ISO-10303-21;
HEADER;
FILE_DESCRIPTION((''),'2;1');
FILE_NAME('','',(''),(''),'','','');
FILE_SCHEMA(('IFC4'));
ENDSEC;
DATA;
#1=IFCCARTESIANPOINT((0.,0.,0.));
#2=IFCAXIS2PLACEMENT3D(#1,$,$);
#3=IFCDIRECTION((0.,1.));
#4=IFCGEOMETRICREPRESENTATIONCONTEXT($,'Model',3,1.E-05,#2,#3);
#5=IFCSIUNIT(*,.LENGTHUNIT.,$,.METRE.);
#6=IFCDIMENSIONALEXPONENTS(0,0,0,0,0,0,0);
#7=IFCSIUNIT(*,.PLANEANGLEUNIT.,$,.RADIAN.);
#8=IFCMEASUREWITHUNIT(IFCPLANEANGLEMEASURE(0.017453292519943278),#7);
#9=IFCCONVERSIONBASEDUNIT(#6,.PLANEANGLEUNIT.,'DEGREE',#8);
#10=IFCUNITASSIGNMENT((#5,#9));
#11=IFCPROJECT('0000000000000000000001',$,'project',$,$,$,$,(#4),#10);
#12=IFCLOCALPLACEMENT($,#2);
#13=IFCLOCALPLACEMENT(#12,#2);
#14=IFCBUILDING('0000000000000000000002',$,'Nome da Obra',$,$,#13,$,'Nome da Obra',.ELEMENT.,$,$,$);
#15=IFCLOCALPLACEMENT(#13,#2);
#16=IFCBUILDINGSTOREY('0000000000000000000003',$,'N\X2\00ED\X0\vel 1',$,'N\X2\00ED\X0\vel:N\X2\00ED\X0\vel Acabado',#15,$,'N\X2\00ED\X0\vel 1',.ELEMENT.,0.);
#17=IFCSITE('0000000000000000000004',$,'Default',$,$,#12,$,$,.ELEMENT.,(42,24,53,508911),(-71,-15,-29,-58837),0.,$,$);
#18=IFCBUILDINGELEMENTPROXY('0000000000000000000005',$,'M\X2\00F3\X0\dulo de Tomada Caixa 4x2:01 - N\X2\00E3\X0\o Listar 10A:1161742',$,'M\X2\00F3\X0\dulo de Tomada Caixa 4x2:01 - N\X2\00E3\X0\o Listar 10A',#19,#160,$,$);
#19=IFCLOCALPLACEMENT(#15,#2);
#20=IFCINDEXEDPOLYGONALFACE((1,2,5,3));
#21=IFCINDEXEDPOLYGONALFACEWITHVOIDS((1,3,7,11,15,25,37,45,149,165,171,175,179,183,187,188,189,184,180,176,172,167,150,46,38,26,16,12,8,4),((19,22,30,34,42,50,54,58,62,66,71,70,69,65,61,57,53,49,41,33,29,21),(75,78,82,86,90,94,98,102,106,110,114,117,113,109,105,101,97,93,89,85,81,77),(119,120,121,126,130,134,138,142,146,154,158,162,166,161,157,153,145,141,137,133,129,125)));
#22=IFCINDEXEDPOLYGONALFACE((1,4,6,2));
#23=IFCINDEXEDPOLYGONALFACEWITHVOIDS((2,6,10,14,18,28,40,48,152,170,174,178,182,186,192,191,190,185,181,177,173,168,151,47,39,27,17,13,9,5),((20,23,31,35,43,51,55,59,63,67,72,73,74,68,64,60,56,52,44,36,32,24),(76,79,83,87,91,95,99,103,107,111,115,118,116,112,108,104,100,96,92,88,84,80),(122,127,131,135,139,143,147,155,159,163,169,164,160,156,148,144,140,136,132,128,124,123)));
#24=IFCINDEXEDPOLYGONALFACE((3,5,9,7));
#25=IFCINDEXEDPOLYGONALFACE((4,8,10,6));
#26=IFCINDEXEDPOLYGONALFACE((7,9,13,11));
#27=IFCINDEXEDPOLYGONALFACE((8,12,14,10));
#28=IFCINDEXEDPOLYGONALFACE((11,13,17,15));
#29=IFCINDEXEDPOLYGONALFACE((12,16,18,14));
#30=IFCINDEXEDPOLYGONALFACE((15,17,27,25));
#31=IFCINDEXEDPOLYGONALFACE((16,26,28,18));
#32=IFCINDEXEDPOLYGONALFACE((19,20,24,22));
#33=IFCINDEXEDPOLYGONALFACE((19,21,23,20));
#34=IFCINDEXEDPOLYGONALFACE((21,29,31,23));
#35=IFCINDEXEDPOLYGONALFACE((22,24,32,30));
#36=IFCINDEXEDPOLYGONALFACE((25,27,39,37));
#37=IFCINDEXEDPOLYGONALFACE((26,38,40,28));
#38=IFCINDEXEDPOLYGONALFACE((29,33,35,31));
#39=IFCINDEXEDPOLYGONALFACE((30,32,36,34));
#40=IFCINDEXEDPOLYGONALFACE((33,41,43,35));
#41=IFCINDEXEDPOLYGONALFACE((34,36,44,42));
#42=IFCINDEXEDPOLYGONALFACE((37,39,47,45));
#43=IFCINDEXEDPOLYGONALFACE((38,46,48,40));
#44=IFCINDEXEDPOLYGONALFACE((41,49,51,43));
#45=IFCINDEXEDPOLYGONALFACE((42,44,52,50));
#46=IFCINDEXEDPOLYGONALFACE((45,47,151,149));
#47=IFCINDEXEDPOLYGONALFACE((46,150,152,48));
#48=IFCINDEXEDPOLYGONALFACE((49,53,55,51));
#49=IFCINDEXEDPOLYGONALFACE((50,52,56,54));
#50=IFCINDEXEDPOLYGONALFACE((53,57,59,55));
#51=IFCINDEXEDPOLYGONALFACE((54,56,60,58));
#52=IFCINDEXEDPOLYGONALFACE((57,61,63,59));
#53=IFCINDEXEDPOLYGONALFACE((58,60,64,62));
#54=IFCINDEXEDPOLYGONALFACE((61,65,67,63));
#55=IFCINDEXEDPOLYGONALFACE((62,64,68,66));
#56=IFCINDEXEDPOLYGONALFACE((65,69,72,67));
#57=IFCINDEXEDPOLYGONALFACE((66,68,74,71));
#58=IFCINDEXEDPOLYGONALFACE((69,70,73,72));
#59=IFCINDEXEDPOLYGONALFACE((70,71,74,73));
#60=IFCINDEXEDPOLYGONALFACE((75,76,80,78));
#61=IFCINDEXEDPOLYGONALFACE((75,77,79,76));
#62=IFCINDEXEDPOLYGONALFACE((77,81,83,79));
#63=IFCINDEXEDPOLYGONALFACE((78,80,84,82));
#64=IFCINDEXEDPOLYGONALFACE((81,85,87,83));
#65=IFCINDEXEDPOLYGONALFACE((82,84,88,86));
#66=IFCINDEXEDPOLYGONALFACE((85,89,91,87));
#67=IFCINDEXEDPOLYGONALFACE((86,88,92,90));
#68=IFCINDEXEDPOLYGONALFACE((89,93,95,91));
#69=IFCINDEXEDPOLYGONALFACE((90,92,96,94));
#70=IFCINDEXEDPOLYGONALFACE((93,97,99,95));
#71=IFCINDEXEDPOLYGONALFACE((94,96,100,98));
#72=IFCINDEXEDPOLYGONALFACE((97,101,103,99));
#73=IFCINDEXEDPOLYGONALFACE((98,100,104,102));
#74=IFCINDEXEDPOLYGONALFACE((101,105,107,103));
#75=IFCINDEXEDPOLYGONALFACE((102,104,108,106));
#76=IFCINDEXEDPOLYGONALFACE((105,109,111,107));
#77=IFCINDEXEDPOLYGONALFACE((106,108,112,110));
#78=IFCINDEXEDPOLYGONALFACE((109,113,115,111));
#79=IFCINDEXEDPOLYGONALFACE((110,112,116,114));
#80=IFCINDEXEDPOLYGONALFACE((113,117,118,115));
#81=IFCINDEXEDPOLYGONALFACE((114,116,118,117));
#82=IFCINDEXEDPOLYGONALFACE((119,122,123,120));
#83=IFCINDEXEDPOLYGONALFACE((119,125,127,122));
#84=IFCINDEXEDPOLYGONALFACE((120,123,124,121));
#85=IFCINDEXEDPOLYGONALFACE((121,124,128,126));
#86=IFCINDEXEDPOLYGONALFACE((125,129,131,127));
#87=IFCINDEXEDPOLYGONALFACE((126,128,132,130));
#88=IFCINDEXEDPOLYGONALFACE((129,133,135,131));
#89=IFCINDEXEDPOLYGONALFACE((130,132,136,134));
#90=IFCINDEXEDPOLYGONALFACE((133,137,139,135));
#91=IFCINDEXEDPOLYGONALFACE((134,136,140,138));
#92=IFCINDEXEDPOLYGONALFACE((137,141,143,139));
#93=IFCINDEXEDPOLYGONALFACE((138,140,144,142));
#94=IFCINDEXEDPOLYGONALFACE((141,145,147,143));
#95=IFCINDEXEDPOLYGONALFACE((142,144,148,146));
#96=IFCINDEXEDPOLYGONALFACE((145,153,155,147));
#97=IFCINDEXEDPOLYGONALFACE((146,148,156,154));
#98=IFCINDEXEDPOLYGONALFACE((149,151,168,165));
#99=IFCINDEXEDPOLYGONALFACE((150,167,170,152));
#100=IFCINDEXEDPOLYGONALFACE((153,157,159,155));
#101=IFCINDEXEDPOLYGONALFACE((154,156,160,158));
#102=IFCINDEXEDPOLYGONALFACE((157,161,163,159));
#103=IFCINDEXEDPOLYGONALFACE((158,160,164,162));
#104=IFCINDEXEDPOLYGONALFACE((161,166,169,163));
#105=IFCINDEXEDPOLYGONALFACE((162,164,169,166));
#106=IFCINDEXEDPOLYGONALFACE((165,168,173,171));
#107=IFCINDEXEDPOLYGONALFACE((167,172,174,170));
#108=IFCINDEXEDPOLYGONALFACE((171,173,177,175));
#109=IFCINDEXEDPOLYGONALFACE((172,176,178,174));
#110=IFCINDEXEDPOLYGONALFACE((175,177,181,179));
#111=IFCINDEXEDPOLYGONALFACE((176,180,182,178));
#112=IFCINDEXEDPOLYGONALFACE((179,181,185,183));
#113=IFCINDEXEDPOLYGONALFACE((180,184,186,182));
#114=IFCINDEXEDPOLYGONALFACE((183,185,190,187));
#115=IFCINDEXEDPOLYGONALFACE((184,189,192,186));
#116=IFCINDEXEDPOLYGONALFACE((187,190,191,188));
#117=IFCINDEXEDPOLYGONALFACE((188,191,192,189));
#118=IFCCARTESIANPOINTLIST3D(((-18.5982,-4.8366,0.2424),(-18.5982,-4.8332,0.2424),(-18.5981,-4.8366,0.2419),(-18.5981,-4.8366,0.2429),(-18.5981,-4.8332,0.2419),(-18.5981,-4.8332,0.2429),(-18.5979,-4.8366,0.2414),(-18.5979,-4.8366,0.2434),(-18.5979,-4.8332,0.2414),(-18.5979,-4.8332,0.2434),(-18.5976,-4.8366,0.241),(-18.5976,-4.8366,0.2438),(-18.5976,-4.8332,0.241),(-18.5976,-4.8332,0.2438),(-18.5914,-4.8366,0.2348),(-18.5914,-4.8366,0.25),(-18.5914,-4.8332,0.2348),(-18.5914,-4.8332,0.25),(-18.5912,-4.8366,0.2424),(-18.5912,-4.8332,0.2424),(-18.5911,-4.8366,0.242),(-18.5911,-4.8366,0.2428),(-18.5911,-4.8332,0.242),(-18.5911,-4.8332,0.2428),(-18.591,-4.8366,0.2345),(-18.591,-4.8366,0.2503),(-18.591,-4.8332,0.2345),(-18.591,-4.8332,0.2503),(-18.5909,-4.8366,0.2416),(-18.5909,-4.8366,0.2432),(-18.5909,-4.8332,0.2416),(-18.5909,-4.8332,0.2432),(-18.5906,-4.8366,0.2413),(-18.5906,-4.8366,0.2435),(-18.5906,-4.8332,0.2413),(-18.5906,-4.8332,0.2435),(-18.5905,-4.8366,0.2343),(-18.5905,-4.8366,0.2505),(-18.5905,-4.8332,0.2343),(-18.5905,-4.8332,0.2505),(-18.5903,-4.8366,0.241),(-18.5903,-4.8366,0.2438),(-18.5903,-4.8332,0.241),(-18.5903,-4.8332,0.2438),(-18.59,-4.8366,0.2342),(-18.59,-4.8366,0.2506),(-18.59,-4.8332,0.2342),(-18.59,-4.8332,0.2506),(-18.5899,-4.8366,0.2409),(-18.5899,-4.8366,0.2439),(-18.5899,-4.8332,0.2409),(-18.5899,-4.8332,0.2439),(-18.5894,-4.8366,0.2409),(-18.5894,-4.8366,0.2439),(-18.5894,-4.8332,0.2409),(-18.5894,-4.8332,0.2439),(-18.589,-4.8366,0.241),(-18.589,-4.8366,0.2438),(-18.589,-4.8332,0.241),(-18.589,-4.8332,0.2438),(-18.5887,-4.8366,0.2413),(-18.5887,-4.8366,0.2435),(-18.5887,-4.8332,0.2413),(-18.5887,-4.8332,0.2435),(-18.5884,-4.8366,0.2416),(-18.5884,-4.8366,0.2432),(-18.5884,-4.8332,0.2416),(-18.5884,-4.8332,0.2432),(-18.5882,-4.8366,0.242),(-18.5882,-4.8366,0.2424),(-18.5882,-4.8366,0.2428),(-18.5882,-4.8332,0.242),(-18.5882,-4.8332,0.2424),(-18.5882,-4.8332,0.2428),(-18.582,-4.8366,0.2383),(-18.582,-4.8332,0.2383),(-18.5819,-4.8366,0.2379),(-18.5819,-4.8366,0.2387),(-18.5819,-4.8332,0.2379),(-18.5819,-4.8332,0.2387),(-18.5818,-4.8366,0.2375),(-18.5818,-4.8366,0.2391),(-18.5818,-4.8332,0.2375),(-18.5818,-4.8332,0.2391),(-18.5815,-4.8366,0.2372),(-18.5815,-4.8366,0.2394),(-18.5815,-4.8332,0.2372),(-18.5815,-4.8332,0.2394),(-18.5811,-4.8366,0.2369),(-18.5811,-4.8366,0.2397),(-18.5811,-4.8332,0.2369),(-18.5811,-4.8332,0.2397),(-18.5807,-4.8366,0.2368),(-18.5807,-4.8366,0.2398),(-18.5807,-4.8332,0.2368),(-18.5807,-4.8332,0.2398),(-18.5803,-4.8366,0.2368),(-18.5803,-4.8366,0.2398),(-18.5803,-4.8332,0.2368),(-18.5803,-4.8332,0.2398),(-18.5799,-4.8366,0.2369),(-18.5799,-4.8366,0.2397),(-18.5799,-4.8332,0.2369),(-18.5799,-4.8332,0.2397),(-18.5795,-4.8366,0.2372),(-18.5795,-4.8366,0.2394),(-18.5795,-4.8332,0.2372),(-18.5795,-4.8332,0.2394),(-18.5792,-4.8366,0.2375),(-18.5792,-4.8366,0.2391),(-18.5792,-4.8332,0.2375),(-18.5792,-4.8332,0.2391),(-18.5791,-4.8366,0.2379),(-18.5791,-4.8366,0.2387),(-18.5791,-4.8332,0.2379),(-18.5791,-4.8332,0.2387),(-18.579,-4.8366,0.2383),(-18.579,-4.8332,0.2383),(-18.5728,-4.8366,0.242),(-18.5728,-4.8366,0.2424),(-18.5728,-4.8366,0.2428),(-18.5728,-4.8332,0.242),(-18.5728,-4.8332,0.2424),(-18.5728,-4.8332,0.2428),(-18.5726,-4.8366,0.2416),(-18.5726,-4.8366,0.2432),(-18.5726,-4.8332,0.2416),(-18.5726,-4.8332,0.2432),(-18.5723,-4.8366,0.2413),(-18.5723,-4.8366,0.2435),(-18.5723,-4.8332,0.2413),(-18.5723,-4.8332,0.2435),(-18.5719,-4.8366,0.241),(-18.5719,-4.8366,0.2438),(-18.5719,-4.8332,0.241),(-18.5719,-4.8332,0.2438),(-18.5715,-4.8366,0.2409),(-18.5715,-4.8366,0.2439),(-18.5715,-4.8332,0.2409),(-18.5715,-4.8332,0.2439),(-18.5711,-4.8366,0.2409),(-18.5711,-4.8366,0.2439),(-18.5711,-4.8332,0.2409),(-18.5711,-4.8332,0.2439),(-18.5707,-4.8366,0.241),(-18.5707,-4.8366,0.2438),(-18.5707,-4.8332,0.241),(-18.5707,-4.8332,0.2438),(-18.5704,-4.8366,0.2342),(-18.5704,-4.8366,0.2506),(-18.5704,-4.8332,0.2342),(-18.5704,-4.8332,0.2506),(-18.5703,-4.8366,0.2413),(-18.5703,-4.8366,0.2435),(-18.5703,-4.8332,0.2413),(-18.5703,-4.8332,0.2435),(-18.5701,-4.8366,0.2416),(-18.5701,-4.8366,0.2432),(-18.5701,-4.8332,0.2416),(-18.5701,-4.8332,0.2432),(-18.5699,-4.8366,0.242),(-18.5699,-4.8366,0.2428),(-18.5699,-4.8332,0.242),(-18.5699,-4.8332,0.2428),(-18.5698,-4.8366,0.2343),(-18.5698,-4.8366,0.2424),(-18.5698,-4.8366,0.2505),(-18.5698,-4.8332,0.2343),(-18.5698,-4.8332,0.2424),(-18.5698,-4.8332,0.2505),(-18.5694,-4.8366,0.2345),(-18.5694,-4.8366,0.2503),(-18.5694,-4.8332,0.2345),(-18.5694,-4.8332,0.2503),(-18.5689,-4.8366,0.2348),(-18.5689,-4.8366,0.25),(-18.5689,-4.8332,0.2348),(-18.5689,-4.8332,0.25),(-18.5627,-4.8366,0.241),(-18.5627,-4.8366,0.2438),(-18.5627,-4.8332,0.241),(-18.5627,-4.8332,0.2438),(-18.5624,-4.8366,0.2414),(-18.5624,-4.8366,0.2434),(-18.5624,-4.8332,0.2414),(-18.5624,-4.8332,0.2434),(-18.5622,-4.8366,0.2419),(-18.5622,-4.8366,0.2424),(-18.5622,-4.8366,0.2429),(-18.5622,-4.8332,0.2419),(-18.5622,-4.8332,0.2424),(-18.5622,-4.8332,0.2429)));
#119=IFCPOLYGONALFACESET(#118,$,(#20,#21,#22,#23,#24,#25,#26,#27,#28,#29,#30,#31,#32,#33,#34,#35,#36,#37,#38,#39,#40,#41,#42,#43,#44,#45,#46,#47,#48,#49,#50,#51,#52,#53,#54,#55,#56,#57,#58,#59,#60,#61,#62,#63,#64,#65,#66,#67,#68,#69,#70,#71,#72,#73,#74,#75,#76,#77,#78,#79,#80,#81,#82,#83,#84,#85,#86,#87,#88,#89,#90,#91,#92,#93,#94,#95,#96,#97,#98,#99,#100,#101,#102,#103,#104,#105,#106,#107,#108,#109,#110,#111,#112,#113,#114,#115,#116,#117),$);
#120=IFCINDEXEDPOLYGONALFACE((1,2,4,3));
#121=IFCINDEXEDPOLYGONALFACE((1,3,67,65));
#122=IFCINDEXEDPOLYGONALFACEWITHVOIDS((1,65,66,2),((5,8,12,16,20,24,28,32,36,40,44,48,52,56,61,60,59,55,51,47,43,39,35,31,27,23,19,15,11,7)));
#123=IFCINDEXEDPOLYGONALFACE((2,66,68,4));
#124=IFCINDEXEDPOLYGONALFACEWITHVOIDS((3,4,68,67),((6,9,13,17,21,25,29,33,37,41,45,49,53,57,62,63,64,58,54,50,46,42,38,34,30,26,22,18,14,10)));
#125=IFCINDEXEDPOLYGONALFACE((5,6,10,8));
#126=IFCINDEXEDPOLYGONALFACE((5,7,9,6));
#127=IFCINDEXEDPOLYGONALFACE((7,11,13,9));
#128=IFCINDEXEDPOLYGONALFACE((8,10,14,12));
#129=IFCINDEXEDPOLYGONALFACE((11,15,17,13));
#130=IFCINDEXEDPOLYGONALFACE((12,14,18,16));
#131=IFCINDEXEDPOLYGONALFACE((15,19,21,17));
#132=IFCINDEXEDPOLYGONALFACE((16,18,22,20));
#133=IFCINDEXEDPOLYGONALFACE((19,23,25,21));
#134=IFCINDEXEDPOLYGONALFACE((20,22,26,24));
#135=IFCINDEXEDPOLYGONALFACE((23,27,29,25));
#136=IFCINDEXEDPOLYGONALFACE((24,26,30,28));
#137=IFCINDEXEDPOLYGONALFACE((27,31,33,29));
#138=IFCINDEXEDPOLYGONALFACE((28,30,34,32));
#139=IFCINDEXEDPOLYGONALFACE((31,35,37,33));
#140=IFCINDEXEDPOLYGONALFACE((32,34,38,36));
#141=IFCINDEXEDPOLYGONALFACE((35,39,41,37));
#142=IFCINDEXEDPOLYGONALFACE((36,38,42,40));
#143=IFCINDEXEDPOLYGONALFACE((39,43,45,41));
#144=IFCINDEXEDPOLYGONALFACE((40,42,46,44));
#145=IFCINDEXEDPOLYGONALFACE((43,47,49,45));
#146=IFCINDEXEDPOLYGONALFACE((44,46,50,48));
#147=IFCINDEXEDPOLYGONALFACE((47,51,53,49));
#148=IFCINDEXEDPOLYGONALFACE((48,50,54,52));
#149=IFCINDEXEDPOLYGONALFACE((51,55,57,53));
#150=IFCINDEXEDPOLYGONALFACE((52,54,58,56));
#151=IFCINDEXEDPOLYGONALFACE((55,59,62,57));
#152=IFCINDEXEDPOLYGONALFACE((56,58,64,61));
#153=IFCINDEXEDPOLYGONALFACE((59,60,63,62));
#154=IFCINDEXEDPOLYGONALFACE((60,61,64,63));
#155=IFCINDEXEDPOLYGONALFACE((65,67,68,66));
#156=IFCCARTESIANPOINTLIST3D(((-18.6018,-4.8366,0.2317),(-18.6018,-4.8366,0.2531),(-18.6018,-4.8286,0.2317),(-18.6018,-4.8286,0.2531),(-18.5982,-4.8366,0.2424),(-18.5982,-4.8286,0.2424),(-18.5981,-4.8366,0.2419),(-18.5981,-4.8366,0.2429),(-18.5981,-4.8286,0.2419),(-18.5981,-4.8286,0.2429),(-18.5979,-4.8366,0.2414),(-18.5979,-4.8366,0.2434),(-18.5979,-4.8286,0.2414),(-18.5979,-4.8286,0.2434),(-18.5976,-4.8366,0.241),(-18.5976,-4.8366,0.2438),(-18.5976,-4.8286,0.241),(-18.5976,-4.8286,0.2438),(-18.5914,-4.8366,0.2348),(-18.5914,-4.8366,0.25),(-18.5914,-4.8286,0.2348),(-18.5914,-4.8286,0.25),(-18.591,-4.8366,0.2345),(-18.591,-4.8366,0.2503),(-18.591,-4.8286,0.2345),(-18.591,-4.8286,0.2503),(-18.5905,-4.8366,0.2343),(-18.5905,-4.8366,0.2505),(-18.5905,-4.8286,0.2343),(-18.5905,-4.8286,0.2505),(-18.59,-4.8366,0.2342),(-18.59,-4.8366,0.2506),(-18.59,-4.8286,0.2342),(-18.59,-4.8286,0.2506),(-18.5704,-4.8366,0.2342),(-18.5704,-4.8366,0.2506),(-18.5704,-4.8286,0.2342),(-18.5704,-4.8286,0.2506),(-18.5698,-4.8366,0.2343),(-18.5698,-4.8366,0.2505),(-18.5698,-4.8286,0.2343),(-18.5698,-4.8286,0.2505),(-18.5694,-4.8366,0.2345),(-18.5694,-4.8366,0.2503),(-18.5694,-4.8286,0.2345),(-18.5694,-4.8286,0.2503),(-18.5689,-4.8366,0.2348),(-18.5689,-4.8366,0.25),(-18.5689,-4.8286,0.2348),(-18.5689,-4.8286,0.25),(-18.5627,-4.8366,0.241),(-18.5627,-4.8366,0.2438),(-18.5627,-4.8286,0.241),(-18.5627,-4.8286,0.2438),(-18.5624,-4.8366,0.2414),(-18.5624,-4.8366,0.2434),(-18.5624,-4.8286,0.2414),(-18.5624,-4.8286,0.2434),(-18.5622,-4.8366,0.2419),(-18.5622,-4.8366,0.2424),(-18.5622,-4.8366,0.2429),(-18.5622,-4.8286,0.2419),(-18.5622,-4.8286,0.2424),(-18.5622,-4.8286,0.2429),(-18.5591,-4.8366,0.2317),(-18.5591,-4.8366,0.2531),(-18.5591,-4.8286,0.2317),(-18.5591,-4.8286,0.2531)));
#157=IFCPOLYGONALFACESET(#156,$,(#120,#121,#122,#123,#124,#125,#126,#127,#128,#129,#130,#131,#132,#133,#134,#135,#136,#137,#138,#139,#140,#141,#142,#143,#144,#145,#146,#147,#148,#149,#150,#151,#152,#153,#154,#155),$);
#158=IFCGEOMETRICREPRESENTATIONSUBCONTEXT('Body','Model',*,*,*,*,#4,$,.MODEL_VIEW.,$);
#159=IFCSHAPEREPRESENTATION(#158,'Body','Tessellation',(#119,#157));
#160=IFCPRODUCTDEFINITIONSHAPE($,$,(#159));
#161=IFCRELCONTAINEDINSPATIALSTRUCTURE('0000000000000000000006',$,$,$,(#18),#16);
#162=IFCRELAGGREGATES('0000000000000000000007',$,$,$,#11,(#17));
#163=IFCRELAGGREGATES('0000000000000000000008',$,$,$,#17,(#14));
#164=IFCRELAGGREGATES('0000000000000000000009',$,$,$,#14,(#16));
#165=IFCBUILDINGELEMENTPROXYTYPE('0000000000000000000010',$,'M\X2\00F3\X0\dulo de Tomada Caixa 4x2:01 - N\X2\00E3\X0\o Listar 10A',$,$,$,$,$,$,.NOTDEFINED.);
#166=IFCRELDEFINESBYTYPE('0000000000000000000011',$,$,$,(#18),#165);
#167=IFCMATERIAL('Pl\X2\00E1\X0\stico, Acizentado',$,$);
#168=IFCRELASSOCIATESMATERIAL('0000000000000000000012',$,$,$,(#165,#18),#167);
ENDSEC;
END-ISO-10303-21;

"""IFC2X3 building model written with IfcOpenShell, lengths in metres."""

from ifc_helpers import new_model, entity, si_unit, converted_unit, direction, frame, frame_2d, origin, place, context, subcontext, project, spatial, polyline, circle_curve, parameter, trimmed, segment, composite_curve, outline, extrude, source, transform, mapped, material, type_object, type_shapes, element, save


model = new_model("IFC2X3")

# Units and contexts
model_context = context("Model", 3, precision=1e-05, world=origin(), true_north=direction((0.0, 1.0)))
body_context = subcontext(model_context, "Body", "Model", "MODEL_VIEW")
ifc_project = project(units=[si_unit("LENGTHUNIT", "METRE"), converted_unit("PLANEANGLEUNIT", "DEGREE", entity("IfcPlaneAngleMeasure", 0.017453292519943278), si_unit("PLANEANGLEUNIT", "RADIAN"), dimensions=[0, 0, 0, 0, 0, 0, 0])], contexts=[model_context])

# Site, building, storey
site_placement = place(None, origin())
site = spatial("IfcSite", under=ifc_project, at=site_placement, Name="Default", CompositionType="ELEMENT", RefLatitude=(42, 24, 53, 508911), RefLongitude=(-71, -15, -29, -58837), RefElevation=0.0)
building_placement = place(site_placement, origin())
building = spatial("IfcBuilding", under=site, at=building_placement, Name="Nome da Obra", LongName="Nome da Obra", CompositionType="ELEMENT")
storey_placement = place(building_placement, origin())
storey = spatial("IfcBuildingStorey", under=building, at=storey_placement, Name="Nível 1", ObjectType="Nível:Nível Acabado", LongName="Nível 1", CompositionType="ELEMENT", Elevation=0.0)

# Building element proxy
ifc_material_1 = material(Name="Plástico, Acizentado")
building_element_proxy_type_1 = type_object("IfcBuildingElementProxyType", Name="Módulo de Tomada Caixa 4x2:01 - Não Listar 10A", PredefinedType="NOTDEFINED", material=ifc_material_1)
shared_shape_1 = source(origin(), body_context, "Body", "SweptSolid", [
    extrude(outline(composite_curve([segment(polyline([(-0.0098, -0.0082), (0.0098, -0.0082)]), True, "CONTINUOUS"), segment(trimmed(circle_curve(frame_2d((0.0098, -0.0062), x_axis=(1.0, 0.0)), 0.002), [parameter(270.0)], [parameter(315.0)], True, "PARAMETER"), True, "CONTINUOUS"), segment(polyline([(0.0112, -0.0076), (0.0174, -0.0014)]), True, "CONTINUOUS"), segment(trimmed(circle_curve(frame_2d((0.016, 0.0), x_axis=(1.0, 0.0)), 0.002), [parameter(315.0)], [parameter(45.0)], True, "PARAMETER"), True, "CONTINUOUS"), segment(polyline([(0.0174, 0.0014), (0.0112, 0.0076)]), True, "CONTINUOUS"), segment(trimmed(circle_curve(frame_2d((0.0098, 0.0062), x_axis=(1.0, 0.0)), 0.002), [parameter(45.0)], [parameter(90.0)], True, "PARAMETER"), True, "CONTINUOUS"), segment(polyline([(0.0098, 0.0082), (-0.0098, 0.0082)]), True, "CONTINUOUS"), segment(trimmed(circle_curve(frame_2d((-0.0098, 0.0062), x_axis=(1.0, 0.0)), 0.002), [parameter(90.0)], [parameter(135.0)], True, "PARAMETER"), True, "CONTINUOUS"), segment(polyline([(-0.0112, 0.0076), (-0.0174, 0.0014)]), True, "CONTINUOUS"), segment(trimmed(circle_curve(frame_2d((-0.016, 0.0), x_axis=(1.0, 0.0)), 0.002), [parameter(135.0)], [parameter(225.0)], True, "PARAMETER"), True, "CONTINUOUS"), segment(polyline([(-0.0174, -0.0014), (-0.0112, -0.0076)]), True, "CONTINUOUS"), segment(trimmed(circle_curve(frame_2d((-0.0098, -0.0062), x_axis=(1.0, 0.0)), 0.002), [parameter(225.0)], [parameter(270.0)], True, "PARAMETER"), True, "CONTINUOUS")], self_intersect=False), holes=[composite_curve([segment(trimmed(circle_curve(frame_2d((0.0089, 0.0), x_axis=(1.0, 0.0)), 0.0015), [parameter(0.0)], [parameter(180.0)], True, "PARAMETER"), False, "CONTINUOUS"), segment(trimmed(circle_curve(frame_2d((0.0089, 0.0), x_axis=(1.0, 0.0)), 0.0015), [parameter(180.0)], [parameter(0.0)], True, "PARAMETER"), False, "CONTINUOUS")], self_intersect=False), composite_curve([segment(trimmed(circle_curve(frame_2d((-0.0003, 0.0041), x_axis=(1.0, 0.0)), 0.0015), [parameter(0.0)], [parameter(180.0)], True, "PARAMETER"), False, "CONTINUOUS"), segment(trimmed(circle_curve(frame_2d((-0.0003, 0.0041), x_axis=(1.0, 0.0)), 0.0015), [parameter(180.0)], [parameter(0.0)], True, "PARAMETER"), False, "CONTINUOUS")], self_intersect=False), composite_curve([segment(trimmed(circle_curve(frame_2d((-0.0095, 0.0), x_axis=(1.0, 0.0)), 0.0015), [parameter(0.0)], [parameter(180.0)], True, "PARAMETER"), False, "CONTINUOUS"), segment(trimmed(circle_curve(frame_2d((-0.0095, 0.0), x_axis=(1.0, 0.0)), 0.0015), [parameter(180.0)], [parameter(0.0)], True, "PARAMETER"), False, "CONTINUOUS")], self_intersect=False)]), frame((0.0003, 0.0, 0.125), z_axis=(0.0, 1.0, 0.0), x_axis=(1.0, 0.0, 0.0)), (0.0, 0.0, 1.0), 0.0034),
    extrude(outline(polyline([(-0.0214, -0.0107), (0.0214, -0.0107), (0.0214, 0.0107), (-0.0214, 0.0107), (-0.0214, -0.0107)]), holes=[composite_curve([segment(polyline([(0.0101, -0.0082), (-0.0095, -0.0082)]), True, "CONTINUOUS"), segment(trimmed(circle_curve(frame_2d((-0.0095, -0.0062), x_axis=(1.0, 0.0)), 0.002), [parameter(225.0)], [parameter(270.0)], True, "PARAMETER"), False, "CONTINUOUS"), segment(polyline([(-0.0109, -0.0076), (-0.0171, -0.0014)]), True, "CONTINUOUS"), segment(trimmed(circle_curve(frame_2d((-0.0157, 0.0), x_axis=(1.0, 0.0)), 0.002), [parameter(135.0)], [parameter(225.0)], True, "PARAMETER"), False, "CONTINUOUS"), segment(polyline([(-0.0171, 0.0014), (-0.0109, 0.0076)]), True, "CONTINUOUS"), segment(trimmed(circle_curve(frame_2d((-0.0095, 0.0062), x_axis=(1.0, 0.0)), 0.002), [parameter(90.0)], [parameter(135.0)], True, "PARAMETER"), False, "CONTINUOUS"), segment(polyline([(-0.0095, 0.0082), (0.0101, 0.0082)]), True, "CONTINUOUS"), segment(trimmed(circle_curve(frame_2d((0.0101, 0.0062), x_axis=(1.0, 0.0)), 0.002), [parameter(45.0)], [parameter(90.0)], True, "PARAMETER"), False, "CONTINUOUS"), segment(polyline([(0.0115, 0.0076), (0.0177, 0.0014)]), True, "CONTINUOUS"), segment(trimmed(circle_curve(frame_2d((0.0163, 0.0), x_axis=(1.0, 0.0)), 0.002), [parameter(315.0)], [parameter(45.0)], True, "PARAMETER"), False, "CONTINUOUS"), segment(polyline([(0.0177, -0.0014), (0.0115, -0.0076)]), True, "CONTINUOUS"), segment(trimmed(circle_curve(frame_2d((0.0101, -0.0062), x_axis=(1.0, 0.0)), 0.002), [parameter(270.0)], [parameter(315.0)], True, "PARAMETER"), False, "CONTINUOUS")], self_intersect=False)]), frame((0.0, 0.0, 0.125), z_axis=(0.0, 1.0, 0.0), x_axis=(1.0, 0.0, 0.0)), (0.0, 0.0, 1.0), 0.008),
])
type_shapes(building_element_proxy_type_1, [shared_shape_1])
for number, where, name in (
    (1, (-18.5805, -4.8366, 0.1174), "Módulo de Tomada Caixa 4x2:01 - Não Listar 10A:1161742"),
):
    element("IfcBuildingElementProxy", number, at=place(storey_placement, frame(where)), inside=storey, type_object=building_element_proxy_type_1, material=ifc_material_1, Name=name, ObjectType="Módulo de Tomada Caixa 4x2:01 - Não Listar 10A", context=body_context, shape_type="MappedRepresentation", body=[
        mapped(shared_shape_1, transform((0.0, 0.0, 0.0), scale=1.0)),
    ])

save(model, "model.ifc")
